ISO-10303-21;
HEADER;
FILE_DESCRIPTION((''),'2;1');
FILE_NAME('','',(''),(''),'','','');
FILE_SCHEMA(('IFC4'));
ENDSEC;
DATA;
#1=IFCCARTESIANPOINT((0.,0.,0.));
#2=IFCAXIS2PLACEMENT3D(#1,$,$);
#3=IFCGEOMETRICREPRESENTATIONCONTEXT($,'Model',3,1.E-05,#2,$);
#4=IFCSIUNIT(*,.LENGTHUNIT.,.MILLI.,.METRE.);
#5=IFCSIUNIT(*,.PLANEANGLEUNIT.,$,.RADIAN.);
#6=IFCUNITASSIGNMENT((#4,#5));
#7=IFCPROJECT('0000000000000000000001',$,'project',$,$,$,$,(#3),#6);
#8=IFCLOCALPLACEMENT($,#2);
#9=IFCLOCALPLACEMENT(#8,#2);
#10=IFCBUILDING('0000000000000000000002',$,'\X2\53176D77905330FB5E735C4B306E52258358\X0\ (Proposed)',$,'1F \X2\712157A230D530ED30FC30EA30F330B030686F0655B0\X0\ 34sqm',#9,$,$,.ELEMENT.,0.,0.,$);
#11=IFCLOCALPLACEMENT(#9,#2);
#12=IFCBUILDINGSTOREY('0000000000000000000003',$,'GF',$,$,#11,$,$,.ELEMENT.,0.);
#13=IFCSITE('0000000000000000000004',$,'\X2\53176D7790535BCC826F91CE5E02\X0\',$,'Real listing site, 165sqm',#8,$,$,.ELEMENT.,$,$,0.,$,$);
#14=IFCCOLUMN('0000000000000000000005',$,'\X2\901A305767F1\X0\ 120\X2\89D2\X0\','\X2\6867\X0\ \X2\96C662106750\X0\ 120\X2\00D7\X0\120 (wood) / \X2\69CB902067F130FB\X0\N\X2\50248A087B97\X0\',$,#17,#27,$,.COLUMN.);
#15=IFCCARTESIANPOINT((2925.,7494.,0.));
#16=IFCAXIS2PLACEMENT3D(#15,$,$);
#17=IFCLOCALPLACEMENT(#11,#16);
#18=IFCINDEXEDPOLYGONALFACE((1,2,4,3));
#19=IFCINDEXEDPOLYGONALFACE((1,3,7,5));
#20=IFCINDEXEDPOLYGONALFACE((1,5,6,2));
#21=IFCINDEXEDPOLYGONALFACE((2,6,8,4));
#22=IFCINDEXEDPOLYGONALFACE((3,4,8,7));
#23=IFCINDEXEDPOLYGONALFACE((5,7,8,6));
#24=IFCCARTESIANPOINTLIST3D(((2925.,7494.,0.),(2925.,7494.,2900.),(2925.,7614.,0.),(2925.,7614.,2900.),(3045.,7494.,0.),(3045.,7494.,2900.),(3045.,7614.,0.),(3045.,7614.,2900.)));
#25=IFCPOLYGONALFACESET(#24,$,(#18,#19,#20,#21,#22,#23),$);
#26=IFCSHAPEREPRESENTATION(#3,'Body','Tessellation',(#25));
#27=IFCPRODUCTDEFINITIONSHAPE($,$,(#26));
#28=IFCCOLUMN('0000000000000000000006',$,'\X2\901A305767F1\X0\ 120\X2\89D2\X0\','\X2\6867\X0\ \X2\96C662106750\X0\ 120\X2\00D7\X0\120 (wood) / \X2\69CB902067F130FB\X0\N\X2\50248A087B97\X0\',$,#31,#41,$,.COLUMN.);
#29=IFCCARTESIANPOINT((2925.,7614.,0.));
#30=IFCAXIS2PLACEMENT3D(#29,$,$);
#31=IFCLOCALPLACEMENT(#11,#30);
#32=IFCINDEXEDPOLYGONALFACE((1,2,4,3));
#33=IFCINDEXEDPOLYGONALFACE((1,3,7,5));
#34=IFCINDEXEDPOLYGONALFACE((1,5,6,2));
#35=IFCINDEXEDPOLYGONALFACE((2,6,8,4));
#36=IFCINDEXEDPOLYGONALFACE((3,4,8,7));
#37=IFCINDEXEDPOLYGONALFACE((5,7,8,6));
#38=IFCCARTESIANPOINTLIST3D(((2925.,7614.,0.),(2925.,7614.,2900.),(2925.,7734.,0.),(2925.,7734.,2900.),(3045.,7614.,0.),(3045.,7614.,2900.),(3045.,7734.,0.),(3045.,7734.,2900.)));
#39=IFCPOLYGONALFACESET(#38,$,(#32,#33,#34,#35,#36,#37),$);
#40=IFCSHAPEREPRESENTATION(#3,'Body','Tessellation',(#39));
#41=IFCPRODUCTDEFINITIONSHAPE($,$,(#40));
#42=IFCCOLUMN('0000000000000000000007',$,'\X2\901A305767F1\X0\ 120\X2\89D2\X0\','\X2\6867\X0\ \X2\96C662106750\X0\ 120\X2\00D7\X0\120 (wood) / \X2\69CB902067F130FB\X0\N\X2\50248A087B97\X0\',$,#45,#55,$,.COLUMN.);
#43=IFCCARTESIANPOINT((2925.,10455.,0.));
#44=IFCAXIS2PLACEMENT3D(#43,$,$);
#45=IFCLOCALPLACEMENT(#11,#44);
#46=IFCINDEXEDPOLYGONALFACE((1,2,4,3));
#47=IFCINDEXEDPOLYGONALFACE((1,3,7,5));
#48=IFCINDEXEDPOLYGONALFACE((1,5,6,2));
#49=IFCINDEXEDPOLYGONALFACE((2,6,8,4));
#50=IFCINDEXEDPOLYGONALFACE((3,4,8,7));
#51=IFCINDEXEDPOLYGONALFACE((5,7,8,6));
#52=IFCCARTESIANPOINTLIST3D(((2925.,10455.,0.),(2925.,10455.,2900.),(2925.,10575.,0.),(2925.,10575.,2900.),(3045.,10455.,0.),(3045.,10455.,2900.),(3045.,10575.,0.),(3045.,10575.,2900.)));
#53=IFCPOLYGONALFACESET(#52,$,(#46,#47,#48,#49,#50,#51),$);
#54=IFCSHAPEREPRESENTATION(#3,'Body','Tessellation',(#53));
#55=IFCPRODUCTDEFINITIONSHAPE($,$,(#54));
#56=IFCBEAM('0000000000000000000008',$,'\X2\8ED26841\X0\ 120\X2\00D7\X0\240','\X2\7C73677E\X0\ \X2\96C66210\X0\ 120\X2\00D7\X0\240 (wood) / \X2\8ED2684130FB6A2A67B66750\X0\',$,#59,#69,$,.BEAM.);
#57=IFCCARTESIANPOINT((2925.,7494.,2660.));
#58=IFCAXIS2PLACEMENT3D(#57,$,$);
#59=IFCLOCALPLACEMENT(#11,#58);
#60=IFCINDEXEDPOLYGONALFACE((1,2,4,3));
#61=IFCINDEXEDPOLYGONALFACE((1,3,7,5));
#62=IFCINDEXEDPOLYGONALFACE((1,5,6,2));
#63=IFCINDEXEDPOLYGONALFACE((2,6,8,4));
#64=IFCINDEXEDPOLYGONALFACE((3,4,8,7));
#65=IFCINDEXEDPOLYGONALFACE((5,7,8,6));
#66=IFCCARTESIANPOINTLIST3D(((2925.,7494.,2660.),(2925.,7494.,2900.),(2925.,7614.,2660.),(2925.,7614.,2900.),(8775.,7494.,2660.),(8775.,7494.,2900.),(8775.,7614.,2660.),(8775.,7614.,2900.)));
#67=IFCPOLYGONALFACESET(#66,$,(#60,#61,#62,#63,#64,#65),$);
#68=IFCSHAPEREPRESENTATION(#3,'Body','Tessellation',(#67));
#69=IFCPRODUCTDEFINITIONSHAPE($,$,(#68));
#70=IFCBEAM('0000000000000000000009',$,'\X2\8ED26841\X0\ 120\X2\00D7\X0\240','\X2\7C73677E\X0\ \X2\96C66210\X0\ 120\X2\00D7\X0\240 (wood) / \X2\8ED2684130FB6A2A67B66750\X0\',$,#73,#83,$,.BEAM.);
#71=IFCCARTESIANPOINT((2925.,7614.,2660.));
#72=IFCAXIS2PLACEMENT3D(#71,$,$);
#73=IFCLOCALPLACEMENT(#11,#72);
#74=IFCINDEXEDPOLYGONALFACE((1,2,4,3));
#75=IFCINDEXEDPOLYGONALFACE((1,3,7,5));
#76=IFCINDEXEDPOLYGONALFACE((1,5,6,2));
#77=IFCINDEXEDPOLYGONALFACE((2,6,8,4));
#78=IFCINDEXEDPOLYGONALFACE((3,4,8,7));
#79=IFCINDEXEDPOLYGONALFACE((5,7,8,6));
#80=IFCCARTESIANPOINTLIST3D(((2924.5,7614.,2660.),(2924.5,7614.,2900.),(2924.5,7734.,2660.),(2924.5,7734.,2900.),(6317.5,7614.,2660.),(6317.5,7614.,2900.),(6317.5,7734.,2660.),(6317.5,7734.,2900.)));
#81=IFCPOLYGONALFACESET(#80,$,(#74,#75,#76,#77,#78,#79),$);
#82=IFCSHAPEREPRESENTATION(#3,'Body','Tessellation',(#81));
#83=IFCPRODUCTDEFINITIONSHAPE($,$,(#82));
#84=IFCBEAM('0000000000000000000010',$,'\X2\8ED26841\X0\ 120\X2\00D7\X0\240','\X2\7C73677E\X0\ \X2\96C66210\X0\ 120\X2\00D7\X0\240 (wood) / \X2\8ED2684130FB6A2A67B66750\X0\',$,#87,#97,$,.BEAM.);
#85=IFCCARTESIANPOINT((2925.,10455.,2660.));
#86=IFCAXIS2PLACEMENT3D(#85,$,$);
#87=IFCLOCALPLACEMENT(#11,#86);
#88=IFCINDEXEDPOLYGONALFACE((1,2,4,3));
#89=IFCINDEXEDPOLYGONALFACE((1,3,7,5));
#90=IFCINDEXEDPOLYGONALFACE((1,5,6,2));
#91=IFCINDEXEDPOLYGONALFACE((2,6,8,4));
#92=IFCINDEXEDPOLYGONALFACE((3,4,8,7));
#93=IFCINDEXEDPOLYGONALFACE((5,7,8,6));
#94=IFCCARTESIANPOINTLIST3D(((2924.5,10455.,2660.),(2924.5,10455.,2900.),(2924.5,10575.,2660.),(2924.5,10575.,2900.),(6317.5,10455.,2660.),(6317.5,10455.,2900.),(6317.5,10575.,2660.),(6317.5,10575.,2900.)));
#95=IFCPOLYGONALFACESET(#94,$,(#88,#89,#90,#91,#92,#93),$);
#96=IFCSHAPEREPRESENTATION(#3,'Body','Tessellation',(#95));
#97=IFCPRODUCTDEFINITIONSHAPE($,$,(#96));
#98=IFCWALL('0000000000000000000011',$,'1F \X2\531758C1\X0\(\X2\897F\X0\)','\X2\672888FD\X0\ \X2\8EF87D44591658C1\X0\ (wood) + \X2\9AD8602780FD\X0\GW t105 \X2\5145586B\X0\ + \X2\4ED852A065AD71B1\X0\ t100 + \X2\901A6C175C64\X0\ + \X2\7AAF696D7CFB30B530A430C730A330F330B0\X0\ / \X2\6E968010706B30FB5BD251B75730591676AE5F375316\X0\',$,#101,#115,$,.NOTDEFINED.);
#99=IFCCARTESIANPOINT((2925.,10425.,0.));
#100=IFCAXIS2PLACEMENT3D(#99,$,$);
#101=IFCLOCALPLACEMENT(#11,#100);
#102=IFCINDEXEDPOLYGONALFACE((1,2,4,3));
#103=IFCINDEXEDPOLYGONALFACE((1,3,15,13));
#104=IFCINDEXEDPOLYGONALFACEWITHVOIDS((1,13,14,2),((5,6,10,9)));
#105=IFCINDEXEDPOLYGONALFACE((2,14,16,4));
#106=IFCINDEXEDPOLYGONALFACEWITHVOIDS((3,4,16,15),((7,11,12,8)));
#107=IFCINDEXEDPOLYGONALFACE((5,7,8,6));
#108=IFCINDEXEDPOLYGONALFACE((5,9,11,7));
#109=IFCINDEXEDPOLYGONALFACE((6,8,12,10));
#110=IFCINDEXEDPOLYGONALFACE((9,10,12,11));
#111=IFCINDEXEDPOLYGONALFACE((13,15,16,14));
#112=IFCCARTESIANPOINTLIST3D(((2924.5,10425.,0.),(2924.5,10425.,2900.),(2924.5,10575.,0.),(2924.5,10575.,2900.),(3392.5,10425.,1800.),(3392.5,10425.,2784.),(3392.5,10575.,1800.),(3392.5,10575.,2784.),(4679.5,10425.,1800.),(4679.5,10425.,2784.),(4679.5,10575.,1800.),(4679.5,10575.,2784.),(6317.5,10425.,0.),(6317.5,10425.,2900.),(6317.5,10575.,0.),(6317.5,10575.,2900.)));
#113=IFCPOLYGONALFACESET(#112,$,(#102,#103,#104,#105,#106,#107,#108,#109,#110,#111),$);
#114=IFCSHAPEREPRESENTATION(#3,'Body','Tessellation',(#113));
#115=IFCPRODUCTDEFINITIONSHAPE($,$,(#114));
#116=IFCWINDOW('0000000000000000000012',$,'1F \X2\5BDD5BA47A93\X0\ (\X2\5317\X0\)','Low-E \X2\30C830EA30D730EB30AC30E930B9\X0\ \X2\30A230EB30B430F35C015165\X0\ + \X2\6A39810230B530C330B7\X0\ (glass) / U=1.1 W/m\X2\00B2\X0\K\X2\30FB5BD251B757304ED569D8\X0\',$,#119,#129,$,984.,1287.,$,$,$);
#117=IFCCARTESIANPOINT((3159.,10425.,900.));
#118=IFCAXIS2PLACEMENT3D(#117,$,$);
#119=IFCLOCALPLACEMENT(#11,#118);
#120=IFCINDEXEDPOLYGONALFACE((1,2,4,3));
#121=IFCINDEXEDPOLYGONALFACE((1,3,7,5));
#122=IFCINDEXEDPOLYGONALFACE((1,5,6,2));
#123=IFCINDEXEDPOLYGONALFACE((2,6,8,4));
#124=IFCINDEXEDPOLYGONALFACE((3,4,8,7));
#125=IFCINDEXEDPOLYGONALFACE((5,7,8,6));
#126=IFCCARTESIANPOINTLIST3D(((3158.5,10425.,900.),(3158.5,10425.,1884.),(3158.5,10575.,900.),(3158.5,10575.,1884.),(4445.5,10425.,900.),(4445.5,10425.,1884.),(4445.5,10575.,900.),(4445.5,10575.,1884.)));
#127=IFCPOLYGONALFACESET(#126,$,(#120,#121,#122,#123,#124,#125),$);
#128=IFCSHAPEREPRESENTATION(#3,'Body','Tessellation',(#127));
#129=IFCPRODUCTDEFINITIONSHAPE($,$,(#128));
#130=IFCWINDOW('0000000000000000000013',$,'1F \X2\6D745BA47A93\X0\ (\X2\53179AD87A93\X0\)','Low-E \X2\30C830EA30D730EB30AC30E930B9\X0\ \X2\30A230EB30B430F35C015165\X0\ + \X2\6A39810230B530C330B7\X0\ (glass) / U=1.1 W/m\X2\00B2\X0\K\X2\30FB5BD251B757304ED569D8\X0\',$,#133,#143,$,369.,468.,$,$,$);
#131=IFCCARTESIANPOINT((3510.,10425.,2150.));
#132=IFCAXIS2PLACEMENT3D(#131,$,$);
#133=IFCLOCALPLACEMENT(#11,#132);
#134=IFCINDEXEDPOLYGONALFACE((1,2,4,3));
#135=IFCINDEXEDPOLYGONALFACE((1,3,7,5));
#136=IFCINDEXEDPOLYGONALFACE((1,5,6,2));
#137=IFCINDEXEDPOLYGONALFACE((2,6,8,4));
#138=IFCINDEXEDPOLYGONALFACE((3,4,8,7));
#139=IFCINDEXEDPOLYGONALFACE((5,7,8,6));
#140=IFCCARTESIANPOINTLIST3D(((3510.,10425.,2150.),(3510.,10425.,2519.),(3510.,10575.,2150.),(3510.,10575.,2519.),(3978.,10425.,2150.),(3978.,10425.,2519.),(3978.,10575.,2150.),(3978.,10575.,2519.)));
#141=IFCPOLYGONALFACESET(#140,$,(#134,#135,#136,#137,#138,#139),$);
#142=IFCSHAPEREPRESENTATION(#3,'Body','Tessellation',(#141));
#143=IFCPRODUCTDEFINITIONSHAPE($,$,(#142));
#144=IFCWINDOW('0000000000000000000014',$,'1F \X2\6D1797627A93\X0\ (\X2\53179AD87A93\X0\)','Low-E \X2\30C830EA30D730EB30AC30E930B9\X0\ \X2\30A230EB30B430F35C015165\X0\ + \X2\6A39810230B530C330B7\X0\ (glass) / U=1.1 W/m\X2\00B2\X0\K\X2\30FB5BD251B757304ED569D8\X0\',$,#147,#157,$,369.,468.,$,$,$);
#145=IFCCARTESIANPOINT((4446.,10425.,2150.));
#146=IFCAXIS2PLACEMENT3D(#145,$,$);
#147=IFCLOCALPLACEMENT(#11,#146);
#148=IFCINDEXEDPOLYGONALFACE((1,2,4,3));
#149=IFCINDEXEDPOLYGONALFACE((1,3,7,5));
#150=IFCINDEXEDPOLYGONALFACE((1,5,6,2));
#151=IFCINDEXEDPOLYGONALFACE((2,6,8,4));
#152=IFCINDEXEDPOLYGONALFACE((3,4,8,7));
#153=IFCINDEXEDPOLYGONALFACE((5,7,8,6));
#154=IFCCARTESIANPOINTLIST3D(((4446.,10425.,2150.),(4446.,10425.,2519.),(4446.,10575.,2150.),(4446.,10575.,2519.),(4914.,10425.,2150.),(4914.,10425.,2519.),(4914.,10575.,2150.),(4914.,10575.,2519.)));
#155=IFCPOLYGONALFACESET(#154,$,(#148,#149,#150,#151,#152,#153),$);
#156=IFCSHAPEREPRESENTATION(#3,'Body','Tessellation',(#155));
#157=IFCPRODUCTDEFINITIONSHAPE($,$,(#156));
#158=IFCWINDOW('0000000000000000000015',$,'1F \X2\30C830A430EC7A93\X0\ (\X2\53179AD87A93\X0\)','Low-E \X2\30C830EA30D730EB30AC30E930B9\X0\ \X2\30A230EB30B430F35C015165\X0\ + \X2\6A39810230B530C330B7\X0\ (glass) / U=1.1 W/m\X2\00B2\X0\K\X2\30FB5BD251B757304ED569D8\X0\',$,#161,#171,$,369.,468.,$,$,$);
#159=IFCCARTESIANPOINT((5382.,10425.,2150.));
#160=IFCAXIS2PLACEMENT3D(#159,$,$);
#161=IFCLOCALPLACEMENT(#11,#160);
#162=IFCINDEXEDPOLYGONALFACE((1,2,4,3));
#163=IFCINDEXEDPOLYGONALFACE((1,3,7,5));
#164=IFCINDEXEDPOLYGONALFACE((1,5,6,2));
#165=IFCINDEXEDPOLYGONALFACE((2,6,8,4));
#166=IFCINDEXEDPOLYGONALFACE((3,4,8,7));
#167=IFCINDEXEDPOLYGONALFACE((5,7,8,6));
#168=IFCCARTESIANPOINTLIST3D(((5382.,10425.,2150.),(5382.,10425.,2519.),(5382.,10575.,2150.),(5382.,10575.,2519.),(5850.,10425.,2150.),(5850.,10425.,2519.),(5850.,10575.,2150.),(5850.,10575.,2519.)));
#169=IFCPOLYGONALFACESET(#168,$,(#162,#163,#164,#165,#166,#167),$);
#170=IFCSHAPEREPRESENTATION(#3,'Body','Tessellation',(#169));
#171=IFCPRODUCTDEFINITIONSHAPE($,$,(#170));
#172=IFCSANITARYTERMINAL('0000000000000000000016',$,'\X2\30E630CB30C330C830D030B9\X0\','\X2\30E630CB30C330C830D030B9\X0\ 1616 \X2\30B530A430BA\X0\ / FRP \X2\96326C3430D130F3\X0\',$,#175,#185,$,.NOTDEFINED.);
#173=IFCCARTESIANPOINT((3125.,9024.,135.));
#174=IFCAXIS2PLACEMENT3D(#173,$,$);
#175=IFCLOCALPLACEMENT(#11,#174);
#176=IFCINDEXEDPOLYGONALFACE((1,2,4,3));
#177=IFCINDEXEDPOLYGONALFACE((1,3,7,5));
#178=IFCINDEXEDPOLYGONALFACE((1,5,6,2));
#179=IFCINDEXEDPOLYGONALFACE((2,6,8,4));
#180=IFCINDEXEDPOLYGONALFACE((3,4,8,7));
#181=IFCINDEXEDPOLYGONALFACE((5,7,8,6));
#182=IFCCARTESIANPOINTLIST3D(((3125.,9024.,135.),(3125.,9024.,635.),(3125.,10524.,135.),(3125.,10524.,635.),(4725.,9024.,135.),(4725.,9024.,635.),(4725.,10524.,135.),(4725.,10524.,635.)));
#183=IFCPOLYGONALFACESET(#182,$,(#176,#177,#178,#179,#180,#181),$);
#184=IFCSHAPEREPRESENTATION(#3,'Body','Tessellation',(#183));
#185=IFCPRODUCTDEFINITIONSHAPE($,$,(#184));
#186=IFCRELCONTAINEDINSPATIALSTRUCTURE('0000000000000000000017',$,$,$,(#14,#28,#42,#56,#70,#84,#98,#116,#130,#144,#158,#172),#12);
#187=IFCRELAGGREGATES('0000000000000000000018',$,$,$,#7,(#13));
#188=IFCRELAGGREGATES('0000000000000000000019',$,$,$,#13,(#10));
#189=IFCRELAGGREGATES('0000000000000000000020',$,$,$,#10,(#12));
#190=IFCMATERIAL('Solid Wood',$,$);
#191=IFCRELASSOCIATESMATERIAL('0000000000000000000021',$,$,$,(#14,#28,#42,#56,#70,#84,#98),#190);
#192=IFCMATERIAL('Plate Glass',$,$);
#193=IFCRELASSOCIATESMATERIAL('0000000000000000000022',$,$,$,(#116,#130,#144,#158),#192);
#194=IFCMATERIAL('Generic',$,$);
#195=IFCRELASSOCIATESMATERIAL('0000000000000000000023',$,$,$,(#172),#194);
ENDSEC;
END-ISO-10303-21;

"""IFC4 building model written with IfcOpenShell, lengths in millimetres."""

from ifc_helpers import new_model, si_unit, frame, frame_2d, origin, place, context, project, spatial, rectangle, extrude, material, element, fill, save


model = new_model("IFC4")

# Units and contexts
model_context = context("Model", 3, precision=1e-05, world=origin())
ifc_project = project(units=[si_unit("LENGTHUNIT", "METRE", prefix="MILLI"), si_unit("PLANEANGLEUNIT", "RADIAN")], contexts=[model_context])

# Site, building, storey
site_placement = place(None, origin())
site = spatial("IfcSite", under=ifc_project, at=site_placement, Name="北海道富良野市", ObjectType="Real listing site, 165sqm", CompositionType="ELEMENT", RefElevation=0.0)
building_placement = place(site_placement, origin())
building = spatial("IfcBuilding", under=site, at=building_placement, Name="北海道・平屋の別荘 (Proposed)", ObjectType="1F 無垢フローリングと漆喰 34sqm", CompositionType="ELEMENT", ElevationOfRefHeight=0.0, ElevationOfTerrain=0.0)
storey_placement = place(building_placement, origin())
storey = spatial("IfcBuildingStorey", under=building, at=storey_placement, Name="GF", CompositionType="ELEMENT", Elevation=0.0)

# Columns
ifc_material_1 = material(Name="Solid Wood")
column_1_placement = place(storey_placement, frame((2925.0, 7494.0, 0.0)))
element("IfcColumn", 1, at=column_1_placement, inside=storey, material=ifc_material_1, Name="通し柱 120角", Description="桧 集成材 120×120 (wood) / 構造柱・N値計算", PredefinedType="COLUMN", context=model_context, shape_type="SweptSolid", body=[
    extrude(rectangle(XDim=120.0, YDim=120.0, at=frame_2d((60.0, 60.0))), frame((2925.0, 7494.0, 0.0)), (0.0, 0.0, 1.0), 2900.0),
])
column_2_placement = place(storey_placement, frame((2925.0, 7614.0, 0.0)))
element("IfcColumn", 2, at=column_2_placement, inside=storey, material=ifc_material_1, Name="通し柱 120角", Description="桧 集成材 120×120 (wood) / 構造柱・N値計算", PredefinedType="COLUMN", context=model_context, shape_type="SweptSolid", body=[
    extrude(rectangle(XDim=120.0, YDim=120.0, at=frame_2d((60.0, 60.0))), frame((2925.0, 7614.0, 0.0)), (0.0, 0.0, 1.0), 2900.0),
])
column_3_placement = place(storey_placement, frame((2925.0, 10455.0, 0.0)))
element("IfcColumn", 3, at=column_3_placement, inside=storey, material=ifc_material_1, Name="通し柱 120角", Description="桧 集成材 120×120 (wood) / 構造柱・N値計算", PredefinedType="COLUMN", context=model_context, shape_type="SweptSolid", body=[
    extrude(rectangle(XDim=120.0, YDim=120.0, at=frame_2d((60.0, 60.0))), frame((2925.0, 10455.0, 0.0)), (0.0, 0.0, 1.0), 2900.0),
])

# Beams
beam_1_placement = place(storey_placement, frame((2925.0, 7494.0, 2660.0)))
element("IfcBeam", 4, at=beam_1_placement, inside=storey, material=ifc_material_1, Name="軒桁 120×240", Description="米松 集成 120×240 (wood) / 軒桁・横架材", PredefinedType="BEAM", context=model_context, shape_type="SweptSolid", body=[
    extrude(rectangle(XDim=5850.0, YDim=120.0, at=frame_2d((2925.0, 60.0))), frame((2925.0, 7494.0, 2660.0)), (0.0, 0.0, 1.0), 240.0),
])
beam_2_placement = place(storey_placement, frame((2925.0, 7614.0, 2660.0)))
element("IfcBeam", 5, at=beam_2_placement, inside=storey, material=ifc_material_1, Name="軒桁 120×240", Description="米松 集成 120×240 (wood) / 軒桁・横架材", PredefinedType="BEAM", context=model_context, shape_type="SweptSolid", body=[
    extrude(rectangle(XDim=3393.0, YDim=120.0, at=frame_2d((1696.0, 60.0))), frame((2925.0, 7614.0, 2660.0)), (0.0, 0.0, 1.0), 240.0),
])
beam_3_placement = place(storey_placement, frame((2925.0, 10455.0, 2660.0)))
element("IfcBeam", 6, at=beam_3_placement, inside=storey, material=ifc_material_1, Name="軒桁 120×240", Description="米松 集成 120×240 (wood) / 軒桁・横架材", PredefinedType="BEAM", context=model_context, shape_type="SweptSolid", body=[
    extrude(rectangle(XDim=3393.0, YDim=120.0, at=frame_2d((1696.0, 60.0))), frame((2925.0, 10455.0, 2660.0)), (0.0, 0.0, 1.0), 240.0),
])

# Wall, openings, windows
wall_1_placement = place(storey_placement, frame((2925.0, 10425.0, 0.0)))
wall_1 = element("IfcWall", 7, at=wall_1_placement, inside=storey, material=ifc_material_1, Name="1F 北壁(西)", Description="木製 軸組外壁 (wood) + 高性能GW t105 充填 + 付加断熱 t100 + 通気層 + 窯業系サイディング / 準耐火・寒冷地外皮強化", PredefinedType="NOTDEFINED", context=model_context, shape_type="SweptSolid", body=[
    extrude(rectangle(XDim=3393.0, YDim=150.0, at=frame_2d((1696.0, 75.0))), frame((2925.0, 10425.0, 0.0)), (0.0, 0.0, 1.0), 2900.0),
])
opening_1_placement = place(storey_placement, frame((3159.0, 10425.0, 900.0)))
opening_1 = element("IfcOpeningElement", 8, at=opening_1_placement, cuts=wall_1, PredefinedType="NOTDEFINED", context=model_context, shape_type="SweptSolid", body=[
    extrude(rectangle(XDim=1287.0, YDim=150.0, at=frame_2d((643.0, 75.0))), frame((3159.0, 10425.0, 900.0)), (0.0, 0.0, 1.0), 984.0),
])
opening_2_placement = place(storey_placement, frame((3510.0, 10425.0, 2150.0)))
opening_2 = element("IfcOpeningElement", 9, at=opening_2_placement, cuts=wall_1, PredefinedType="NOTDEFINED", context=model_context, shape_type="SweptSolid", body=[
    extrude(rectangle(XDim=468.0, YDim=150.0, at=frame_2d((234.0, 75.0))), frame((3510.0, 10425.0, 2150.0)), (0.0, 0.0, 1.0), 369.0),
])
opening_3_placement = place(storey_placement, frame((4446.0, 10425.0, 2150.0)))
opening_3 = element("IfcOpeningElement", 10, at=opening_3_placement, cuts=wall_1, PredefinedType="NOTDEFINED", context=model_context, shape_type="SweptSolid", body=[
    extrude(rectangle(XDim=468.0, YDim=150.0, at=frame_2d((234.0, 75.0))), frame((4446.0, 10425.0, 2150.0)), (0.0, 0.0, 1.0), 369.0),
])
opening_4_placement = place(storey_placement, frame((5382.0, 10425.0, 2150.0)))
opening_4 = element("IfcOpeningElement", 11, at=opening_4_placement, cuts=wall_1, PredefinedType="NOTDEFINED", context=model_context, shape_type="SweptSolid", body=[
    extrude(rectangle(XDim=468.0, YDim=150.0, at=frame_2d((234.0, 75.0))), frame((5382.0, 10425.0, 2150.0)), (0.0, 0.0, 1.0), 369.0),
])
ifc_material_2 = material(Name="Plate Glass")
window_1_placement = place(storey_placement, frame((3159.0, 10425.0, 900.0)))
window_1 = element("IfcWindow", 12, at=window_1_placement, inside=storey, material=ifc_material_2, Name="1F 寝室窓 (北)", Description="Low-E トリプルガラス アルゴン封入 + 樹脂サッシ (glass) / U=1.1 W/m²K・寒冷地仕様", OverallHeight=984.0, OverallWidth=1287.0, context=model_context, shape_type="SweptSolid", body=[
    extrude(rectangle(XDim=1287.0, YDim=150.0, at=frame_2d((643.0, 75.0))), frame((3159.0, 10425.0, 900.0)), (0.0, 0.0, 1.0), 984.0),
])
fill(opening_1, window_1)
window_2_placement = place(storey_placement, frame((3510.0, 10425.0, 2150.0)))
window_2 = element("IfcWindow", 13, at=window_2_placement, inside=storey, material=ifc_material_2, Name="1F 浴室窓 (北高窓)", Description="Low-E トリプルガラス アルゴン封入 + 樹脂サッシ (glass) / U=1.1 W/m²K・寒冷地仕様", OverallHeight=369.0, OverallWidth=468.0, context=model_context, shape_type="SweptSolid", body=[
    extrude(rectangle(XDim=468.0, YDim=150.0, at=frame_2d((234.0, 75.0))), frame((3510.0, 10425.0, 2150.0)), (0.0, 0.0, 1.0), 369.0),
])
fill(opening_2, window_2)
window_3_placement = place(storey_placement, frame((4446.0, 10425.0, 2150.0)))
window_3 = element("IfcWindow", 14, at=window_3_placement, inside=storey, material=ifc_material_2, Name="1F 洗面窓 (北高窓)", Description="Low-E トリプルガラス アルゴン封入 + 樹脂サッシ (glass) / U=1.1 W/m²K・寒冷地仕様", OverallHeight=369.0, OverallWidth=468.0, context=model_context, shape_type="SweptSolid", body=[
    extrude(rectangle(XDim=468.0, YDim=150.0, at=frame_2d((234.0, 75.0))), frame((4446.0, 10425.0, 2150.0)), (0.0, 0.0, 1.0), 369.0),
])
fill(opening_3, window_3)
window_4_placement = place(storey_placement, frame((5382.0, 10425.0, 2150.0)))
window_4 = element("IfcWindow", 15, at=window_4_placement, inside=storey, material=ifc_material_2, Name="1F トイレ窓 (北高窓)", Description="Low-E トリプルガラス アルゴン封入 + 樹脂サッシ (glass) / U=1.1 W/m²K・寒冷地仕様", OverallHeight=369.0, OverallWidth=468.0, context=model_context, shape_type="SweptSolid", body=[
    extrude(rectangle(XDim=468.0, YDim=150.0, at=frame_2d((234.0, 75.0))), frame((5382.0, 10425.0, 2150.0)), (0.0, 0.0, 1.0), 369.0),
])
fill(opening_4, window_4)

# Shared definitions
ifc_material_3 = material(Name="Generic")

# Sanitary terminal
sanitary_terminal_placement = place(storey_placement, frame((3125.0, 9024.0, 135.0)))
element("IfcSanitaryTerminal", 16, at=sanitary_terminal_placement, inside=storey, material=ifc_material_3, Name="ユニットバス", Description="ユニットバス 1616 サイズ / FRP 防水パン", PredefinedType="NOTDEFINED", context=model_context, shape_type="SweptSolid", body=[
    extrude(rectangle(XDim=1600.0, YDim=1500.0, at=frame_2d((800.0, 750.0))), frame((3125.0, 9024.0, 135.0)), (0.0, 0.0, 1.0), 500.0),
])

save(model, "model.ifc")
